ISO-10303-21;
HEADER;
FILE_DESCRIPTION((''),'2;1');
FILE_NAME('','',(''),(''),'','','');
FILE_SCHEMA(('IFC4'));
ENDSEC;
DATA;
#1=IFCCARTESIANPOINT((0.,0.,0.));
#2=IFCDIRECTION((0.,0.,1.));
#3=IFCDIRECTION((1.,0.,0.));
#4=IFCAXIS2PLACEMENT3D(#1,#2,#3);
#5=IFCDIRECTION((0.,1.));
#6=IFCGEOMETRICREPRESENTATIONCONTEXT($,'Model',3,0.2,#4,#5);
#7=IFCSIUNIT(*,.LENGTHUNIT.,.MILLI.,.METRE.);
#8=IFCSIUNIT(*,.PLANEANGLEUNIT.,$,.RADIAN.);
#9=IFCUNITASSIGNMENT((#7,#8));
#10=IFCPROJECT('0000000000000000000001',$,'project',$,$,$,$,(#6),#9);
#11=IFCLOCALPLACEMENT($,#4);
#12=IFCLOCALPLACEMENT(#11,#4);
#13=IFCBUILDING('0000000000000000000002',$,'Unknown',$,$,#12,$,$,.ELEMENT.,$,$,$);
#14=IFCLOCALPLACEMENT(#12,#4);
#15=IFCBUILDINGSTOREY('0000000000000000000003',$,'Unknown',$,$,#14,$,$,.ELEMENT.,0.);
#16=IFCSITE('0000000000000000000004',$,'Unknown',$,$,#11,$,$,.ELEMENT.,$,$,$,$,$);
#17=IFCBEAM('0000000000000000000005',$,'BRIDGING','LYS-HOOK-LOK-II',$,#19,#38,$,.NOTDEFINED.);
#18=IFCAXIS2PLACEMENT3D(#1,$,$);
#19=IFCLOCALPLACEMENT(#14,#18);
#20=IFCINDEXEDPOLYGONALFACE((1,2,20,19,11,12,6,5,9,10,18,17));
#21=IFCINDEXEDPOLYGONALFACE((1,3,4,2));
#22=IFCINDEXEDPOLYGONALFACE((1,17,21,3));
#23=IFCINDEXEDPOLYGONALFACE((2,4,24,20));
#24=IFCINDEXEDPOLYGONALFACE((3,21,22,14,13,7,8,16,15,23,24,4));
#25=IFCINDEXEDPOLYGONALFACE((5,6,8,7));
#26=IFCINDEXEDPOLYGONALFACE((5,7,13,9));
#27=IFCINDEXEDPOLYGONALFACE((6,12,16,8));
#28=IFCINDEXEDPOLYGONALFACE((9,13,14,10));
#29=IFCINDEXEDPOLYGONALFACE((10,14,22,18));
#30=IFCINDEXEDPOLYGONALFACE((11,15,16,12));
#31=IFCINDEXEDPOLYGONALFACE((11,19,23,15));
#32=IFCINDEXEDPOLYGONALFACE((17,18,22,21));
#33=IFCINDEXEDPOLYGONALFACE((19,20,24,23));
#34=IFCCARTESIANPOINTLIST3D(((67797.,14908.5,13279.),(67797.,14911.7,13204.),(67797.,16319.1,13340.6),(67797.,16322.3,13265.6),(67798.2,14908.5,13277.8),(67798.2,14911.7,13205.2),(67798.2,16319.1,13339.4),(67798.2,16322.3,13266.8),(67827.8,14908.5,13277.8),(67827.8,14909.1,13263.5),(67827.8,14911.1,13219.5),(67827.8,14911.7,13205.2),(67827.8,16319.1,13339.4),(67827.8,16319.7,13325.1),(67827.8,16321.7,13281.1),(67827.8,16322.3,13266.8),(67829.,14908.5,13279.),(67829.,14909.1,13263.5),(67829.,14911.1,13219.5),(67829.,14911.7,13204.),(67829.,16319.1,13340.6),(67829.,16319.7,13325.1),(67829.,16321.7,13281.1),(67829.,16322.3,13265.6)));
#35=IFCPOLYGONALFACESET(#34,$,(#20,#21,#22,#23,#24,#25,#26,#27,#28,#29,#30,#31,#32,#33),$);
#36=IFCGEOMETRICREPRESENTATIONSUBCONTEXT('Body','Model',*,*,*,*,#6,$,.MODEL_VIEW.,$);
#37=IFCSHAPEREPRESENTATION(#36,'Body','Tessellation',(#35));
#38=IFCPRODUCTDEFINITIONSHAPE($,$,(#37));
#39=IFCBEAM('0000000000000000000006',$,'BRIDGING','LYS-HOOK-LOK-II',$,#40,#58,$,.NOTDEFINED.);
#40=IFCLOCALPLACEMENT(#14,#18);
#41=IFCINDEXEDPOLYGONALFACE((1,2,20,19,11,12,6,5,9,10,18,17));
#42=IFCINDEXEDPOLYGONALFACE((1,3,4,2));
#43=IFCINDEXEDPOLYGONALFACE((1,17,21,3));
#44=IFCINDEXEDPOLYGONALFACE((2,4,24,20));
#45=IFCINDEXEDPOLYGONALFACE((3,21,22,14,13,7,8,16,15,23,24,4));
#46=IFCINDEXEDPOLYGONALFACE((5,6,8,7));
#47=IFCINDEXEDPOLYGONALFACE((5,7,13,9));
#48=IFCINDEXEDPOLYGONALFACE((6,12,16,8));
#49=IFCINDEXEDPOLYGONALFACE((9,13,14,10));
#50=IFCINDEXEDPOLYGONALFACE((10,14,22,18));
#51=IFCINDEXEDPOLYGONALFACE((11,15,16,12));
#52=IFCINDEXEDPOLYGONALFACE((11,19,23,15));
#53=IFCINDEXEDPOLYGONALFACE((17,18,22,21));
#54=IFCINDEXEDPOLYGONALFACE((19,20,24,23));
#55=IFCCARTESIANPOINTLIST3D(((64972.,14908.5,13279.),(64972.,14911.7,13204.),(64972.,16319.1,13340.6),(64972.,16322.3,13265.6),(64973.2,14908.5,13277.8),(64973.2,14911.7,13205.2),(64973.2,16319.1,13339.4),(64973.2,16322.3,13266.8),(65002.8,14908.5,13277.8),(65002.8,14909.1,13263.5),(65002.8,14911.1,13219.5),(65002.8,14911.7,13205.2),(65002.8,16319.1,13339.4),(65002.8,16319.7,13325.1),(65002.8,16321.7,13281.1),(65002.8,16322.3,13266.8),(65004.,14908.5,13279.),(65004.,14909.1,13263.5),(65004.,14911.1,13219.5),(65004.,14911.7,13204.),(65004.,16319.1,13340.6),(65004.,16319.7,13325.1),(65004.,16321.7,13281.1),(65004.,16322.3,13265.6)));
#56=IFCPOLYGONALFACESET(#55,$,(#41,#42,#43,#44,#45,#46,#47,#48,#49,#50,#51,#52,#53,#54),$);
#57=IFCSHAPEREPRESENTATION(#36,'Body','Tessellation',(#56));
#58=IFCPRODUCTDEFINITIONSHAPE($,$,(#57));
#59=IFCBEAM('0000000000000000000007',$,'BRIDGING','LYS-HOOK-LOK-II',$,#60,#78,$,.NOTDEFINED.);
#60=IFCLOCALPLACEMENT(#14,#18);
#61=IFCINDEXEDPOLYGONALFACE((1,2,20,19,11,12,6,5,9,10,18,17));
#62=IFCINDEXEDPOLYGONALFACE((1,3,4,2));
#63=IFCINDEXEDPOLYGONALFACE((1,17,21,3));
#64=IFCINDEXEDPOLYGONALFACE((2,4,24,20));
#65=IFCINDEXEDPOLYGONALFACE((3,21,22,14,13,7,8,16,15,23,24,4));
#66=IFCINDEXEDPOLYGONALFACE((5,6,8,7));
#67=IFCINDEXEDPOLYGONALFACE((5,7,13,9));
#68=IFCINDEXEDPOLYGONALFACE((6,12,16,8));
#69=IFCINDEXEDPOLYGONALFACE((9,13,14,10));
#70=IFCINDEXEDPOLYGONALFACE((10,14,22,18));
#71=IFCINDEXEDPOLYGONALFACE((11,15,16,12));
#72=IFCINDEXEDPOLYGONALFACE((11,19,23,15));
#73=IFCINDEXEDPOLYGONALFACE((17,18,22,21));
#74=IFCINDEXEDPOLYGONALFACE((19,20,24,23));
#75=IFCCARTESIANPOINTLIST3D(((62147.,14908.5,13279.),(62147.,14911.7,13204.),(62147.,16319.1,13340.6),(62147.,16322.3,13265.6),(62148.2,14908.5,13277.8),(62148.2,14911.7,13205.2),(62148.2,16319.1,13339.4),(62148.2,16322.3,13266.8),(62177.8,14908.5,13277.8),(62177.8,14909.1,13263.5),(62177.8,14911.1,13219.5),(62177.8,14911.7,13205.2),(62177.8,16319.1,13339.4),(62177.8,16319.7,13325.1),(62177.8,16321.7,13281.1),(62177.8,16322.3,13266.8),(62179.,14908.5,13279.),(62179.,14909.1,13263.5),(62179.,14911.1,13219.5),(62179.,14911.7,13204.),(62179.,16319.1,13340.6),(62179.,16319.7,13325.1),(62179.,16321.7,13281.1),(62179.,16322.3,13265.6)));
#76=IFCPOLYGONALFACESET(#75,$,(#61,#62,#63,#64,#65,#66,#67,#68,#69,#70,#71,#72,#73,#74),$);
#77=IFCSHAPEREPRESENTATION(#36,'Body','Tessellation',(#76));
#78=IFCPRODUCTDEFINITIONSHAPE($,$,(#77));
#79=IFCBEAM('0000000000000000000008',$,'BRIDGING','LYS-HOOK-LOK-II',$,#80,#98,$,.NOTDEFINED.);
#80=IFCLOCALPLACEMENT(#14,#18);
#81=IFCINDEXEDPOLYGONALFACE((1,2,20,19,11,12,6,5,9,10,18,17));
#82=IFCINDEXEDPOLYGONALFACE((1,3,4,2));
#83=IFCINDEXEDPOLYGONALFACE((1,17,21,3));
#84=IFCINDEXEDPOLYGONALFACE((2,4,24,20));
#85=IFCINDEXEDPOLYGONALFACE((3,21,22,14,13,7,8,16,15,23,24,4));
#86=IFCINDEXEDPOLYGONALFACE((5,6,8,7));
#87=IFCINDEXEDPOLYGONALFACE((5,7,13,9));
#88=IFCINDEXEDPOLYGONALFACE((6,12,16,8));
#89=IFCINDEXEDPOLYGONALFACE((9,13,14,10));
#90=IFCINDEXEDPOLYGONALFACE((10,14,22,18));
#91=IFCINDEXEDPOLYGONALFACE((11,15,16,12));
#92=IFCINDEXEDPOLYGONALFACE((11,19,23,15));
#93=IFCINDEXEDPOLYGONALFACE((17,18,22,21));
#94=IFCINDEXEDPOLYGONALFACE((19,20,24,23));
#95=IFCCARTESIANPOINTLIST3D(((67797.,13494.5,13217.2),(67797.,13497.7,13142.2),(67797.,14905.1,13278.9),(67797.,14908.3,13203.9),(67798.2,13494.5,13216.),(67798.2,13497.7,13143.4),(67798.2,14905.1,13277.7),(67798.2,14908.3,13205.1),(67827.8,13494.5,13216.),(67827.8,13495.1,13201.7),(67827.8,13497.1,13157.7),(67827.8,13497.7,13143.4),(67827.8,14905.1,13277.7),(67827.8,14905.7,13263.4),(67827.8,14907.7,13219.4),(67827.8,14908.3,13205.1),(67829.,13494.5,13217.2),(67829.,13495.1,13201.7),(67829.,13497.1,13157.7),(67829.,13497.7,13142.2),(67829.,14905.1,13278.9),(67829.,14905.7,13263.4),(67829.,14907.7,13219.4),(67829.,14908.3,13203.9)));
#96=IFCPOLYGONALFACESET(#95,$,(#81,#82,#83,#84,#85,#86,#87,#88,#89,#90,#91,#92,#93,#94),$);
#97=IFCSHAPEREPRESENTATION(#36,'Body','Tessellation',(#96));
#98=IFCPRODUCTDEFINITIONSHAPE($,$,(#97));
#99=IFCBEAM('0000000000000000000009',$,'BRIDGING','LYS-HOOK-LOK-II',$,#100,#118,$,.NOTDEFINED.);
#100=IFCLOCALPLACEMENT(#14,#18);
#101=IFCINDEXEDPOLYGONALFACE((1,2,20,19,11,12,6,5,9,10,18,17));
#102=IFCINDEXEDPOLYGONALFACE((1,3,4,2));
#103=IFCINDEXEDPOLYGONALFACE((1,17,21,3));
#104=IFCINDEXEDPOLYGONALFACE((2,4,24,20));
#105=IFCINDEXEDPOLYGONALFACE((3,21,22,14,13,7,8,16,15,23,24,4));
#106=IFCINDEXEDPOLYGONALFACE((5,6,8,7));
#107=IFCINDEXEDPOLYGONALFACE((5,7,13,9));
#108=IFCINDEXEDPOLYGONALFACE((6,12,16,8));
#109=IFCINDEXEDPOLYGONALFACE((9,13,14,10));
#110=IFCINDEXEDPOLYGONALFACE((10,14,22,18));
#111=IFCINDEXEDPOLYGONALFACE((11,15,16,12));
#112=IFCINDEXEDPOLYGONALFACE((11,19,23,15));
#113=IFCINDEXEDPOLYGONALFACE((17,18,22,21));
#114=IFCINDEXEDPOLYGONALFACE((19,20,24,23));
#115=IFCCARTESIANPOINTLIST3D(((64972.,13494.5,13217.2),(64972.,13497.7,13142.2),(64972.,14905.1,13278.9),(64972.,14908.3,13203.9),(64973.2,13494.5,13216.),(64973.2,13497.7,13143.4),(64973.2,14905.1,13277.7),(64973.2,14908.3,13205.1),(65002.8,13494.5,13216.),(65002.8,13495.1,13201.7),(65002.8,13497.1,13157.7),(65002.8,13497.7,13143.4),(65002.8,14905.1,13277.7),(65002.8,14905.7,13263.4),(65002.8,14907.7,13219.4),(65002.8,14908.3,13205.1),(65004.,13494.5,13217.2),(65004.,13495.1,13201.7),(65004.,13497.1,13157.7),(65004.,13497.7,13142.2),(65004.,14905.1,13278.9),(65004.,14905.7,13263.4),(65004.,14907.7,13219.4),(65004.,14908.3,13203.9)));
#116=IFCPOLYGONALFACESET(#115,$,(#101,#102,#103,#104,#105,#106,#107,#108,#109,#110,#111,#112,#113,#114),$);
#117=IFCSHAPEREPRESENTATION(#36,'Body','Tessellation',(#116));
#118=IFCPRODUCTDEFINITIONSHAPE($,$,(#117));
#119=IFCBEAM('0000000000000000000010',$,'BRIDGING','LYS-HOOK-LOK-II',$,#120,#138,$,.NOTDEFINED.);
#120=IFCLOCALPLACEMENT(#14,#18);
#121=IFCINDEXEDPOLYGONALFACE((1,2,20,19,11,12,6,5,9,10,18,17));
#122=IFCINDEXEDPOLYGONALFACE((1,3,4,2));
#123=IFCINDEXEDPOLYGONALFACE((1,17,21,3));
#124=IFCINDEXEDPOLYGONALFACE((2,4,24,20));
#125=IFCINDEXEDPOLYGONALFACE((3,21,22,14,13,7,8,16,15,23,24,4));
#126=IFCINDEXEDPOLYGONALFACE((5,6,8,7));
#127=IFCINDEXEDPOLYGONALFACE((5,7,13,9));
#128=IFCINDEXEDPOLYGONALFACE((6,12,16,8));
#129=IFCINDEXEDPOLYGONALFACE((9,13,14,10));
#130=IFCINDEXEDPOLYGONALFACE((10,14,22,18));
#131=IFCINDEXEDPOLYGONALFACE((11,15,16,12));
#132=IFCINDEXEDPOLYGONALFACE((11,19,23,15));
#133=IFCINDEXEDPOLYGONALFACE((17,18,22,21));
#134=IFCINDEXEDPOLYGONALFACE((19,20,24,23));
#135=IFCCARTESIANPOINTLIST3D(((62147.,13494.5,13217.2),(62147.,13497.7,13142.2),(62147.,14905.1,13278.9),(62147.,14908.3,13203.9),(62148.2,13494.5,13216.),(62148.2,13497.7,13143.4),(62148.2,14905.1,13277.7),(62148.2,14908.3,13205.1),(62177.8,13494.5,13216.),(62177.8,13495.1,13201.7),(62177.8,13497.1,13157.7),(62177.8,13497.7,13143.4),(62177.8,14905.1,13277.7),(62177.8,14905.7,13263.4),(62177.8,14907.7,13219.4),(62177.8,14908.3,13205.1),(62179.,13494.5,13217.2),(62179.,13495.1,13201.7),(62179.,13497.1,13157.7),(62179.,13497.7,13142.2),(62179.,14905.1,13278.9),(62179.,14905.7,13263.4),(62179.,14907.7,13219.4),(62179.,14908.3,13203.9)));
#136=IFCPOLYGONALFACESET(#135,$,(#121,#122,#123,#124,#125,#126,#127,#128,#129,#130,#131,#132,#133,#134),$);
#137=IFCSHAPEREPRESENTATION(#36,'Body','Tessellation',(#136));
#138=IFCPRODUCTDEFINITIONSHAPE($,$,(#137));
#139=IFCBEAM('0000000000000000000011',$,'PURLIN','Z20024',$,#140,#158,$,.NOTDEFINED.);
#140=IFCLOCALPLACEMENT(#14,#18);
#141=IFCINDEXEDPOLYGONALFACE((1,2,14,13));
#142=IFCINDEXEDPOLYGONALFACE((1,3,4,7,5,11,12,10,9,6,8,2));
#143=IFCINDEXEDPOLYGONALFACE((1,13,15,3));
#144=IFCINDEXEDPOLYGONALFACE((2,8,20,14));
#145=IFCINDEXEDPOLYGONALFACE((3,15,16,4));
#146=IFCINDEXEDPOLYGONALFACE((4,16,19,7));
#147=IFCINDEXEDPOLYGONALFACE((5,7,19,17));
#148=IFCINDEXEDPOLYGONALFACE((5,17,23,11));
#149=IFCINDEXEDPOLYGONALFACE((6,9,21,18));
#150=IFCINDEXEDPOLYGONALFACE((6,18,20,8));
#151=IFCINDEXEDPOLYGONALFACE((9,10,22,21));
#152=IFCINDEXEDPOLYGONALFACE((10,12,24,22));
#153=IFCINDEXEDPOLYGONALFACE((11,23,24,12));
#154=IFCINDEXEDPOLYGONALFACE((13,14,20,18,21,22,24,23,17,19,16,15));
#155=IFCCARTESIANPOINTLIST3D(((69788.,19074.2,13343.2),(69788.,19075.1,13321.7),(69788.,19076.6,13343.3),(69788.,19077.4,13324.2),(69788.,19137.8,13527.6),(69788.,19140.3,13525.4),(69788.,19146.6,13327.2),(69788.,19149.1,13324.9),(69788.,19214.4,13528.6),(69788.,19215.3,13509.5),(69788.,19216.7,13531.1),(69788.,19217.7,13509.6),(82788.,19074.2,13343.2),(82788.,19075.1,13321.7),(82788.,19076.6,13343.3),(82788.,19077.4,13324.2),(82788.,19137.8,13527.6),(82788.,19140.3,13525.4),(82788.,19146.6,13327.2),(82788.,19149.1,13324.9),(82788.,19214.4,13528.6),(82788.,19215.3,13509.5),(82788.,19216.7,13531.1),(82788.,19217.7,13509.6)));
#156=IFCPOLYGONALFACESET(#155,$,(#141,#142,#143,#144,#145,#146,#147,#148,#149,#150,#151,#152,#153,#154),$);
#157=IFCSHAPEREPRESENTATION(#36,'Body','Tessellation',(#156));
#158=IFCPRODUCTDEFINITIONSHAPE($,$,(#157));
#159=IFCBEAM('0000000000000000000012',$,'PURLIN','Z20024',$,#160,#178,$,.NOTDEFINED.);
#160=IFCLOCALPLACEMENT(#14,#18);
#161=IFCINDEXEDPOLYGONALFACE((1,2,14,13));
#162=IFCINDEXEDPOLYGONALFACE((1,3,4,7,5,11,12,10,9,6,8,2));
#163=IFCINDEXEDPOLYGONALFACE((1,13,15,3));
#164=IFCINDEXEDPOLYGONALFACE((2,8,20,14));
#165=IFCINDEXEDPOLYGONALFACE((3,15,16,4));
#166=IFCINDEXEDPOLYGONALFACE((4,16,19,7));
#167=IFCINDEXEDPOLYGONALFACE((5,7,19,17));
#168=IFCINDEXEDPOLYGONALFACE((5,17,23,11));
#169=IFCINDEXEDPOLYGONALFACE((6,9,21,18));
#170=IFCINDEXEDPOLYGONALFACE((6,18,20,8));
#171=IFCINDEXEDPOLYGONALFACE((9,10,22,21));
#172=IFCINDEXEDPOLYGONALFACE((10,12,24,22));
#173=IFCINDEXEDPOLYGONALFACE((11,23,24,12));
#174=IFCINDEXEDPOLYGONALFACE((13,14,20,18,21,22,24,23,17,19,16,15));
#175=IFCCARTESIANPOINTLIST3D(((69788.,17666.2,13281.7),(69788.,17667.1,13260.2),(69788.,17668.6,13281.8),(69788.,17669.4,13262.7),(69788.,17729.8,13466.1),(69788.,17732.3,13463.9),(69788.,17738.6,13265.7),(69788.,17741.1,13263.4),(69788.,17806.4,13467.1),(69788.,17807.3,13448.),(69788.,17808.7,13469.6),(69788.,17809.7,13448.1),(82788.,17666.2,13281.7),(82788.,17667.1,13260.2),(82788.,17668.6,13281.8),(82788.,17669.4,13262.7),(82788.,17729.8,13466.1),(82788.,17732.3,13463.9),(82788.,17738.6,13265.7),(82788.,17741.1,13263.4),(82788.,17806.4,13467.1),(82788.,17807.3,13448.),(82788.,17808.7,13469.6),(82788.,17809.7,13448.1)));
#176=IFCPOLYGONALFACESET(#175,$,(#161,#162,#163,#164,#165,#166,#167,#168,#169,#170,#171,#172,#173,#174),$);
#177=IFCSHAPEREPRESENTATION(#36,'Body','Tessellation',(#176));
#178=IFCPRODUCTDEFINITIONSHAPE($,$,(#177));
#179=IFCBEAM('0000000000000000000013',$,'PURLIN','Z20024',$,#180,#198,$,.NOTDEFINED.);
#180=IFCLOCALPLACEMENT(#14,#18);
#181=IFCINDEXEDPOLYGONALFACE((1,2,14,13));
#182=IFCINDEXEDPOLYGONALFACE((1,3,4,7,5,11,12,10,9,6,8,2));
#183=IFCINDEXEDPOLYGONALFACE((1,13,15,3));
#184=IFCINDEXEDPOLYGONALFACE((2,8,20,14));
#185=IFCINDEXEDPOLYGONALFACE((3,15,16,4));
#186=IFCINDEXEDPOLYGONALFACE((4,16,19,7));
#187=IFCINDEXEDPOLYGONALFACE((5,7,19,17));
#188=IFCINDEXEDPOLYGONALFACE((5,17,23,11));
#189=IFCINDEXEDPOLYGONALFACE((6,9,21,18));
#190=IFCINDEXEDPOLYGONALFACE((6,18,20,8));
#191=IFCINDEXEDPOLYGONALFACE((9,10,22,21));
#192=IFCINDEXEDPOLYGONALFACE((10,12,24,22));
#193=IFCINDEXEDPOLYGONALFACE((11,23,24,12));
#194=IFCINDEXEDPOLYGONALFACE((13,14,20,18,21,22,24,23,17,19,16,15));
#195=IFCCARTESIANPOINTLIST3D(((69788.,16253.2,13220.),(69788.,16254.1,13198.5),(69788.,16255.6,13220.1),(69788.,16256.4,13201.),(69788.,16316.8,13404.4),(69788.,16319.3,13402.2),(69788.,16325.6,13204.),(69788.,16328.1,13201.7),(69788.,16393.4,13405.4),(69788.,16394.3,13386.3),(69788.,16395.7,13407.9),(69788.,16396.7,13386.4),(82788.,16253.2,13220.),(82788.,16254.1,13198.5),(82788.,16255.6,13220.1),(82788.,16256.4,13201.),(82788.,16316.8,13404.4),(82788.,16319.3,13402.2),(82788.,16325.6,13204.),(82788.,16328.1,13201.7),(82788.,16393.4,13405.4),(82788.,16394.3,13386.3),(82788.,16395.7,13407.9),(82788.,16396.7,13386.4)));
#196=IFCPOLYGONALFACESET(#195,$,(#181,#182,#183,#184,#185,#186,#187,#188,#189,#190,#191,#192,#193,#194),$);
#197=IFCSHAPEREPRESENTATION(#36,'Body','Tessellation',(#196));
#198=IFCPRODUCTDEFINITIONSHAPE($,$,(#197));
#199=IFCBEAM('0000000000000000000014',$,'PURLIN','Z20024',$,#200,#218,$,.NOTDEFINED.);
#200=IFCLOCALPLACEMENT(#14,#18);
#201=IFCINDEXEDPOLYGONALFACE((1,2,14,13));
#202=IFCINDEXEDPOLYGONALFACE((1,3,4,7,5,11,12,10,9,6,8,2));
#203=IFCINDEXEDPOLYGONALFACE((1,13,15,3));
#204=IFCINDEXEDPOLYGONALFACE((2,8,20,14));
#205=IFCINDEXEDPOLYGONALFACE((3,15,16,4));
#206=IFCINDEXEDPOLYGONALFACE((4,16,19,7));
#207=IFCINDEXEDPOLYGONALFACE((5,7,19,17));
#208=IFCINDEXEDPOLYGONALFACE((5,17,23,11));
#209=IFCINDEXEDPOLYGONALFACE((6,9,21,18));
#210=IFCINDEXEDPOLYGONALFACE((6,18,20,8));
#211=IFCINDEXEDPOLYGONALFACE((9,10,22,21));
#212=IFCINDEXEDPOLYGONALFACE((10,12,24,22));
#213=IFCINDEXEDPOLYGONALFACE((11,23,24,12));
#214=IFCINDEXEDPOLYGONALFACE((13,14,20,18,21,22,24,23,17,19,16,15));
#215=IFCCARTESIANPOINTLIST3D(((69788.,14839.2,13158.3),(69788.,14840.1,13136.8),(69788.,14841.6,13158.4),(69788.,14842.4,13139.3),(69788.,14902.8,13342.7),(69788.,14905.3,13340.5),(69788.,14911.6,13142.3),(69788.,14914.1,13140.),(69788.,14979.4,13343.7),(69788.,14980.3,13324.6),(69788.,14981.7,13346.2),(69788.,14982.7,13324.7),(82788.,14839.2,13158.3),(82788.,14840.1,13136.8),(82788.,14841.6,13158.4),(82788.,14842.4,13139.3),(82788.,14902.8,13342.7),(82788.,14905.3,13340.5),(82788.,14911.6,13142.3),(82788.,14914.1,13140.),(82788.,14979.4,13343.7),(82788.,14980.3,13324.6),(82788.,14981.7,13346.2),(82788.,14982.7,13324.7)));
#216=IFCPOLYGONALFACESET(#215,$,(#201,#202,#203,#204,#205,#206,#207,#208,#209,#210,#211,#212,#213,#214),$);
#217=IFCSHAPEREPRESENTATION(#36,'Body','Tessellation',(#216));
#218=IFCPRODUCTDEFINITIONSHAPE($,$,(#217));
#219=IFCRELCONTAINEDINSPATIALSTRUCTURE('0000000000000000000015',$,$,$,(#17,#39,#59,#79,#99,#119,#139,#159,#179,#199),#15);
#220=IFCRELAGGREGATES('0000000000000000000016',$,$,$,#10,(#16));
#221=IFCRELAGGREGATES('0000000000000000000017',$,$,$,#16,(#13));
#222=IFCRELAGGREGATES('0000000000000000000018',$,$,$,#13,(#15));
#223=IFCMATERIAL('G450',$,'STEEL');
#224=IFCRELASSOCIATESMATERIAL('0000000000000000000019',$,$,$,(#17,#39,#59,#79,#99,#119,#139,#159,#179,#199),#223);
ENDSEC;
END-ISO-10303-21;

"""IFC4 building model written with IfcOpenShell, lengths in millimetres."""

from ifc_helpers import new_model, si_unit, direction, frame, origin_with_axes, place, context, subcontext, project, spatial, line, indexed_curve, outline, extrude, material, element, save


model = new_model("IFC4")

# Units and contexts
model_context = context("Model", 3, precision=0.2, world=origin_with_axes(), true_north=direction((0.0, 1.0)))
body_context = subcontext(model_context, "Body", "Model", "MODEL_VIEW")
ifc_project = project(units=[si_unit("LENGTHUNIT", "METRE", prefix="MILLI"), si_unit("PLANEANGLEUNIT", "RADIAN")], contexts=[model_context])

# Site, building, storey
site_placement = place(None, origin_with_axes())
site = spatial("IfcSite", under=ifc_project, at=site_placement, Name="Unknown", CompositionType="ELEMENT")
building_placement = place(site_placement, origin_with_axes())
building = spatial("IfcBuilding", under=site, at=building_placement, Name="Unknown", CompositionType="ELEMENT")
storey_placement = place(building_placement, origin_with_axes())
storey = spatial("IfcBuildingStorey", under=building, at=storey_placement, Name="Unknown", CompositionType="ELEMENT", Elevation=0.0)

# Beams
ifc_material_1 = material(Name="G450", Category="STEEL")
for number, where, z_axis, x_axis, name in (
    (1, (67813.0, 14910.1, 13241.5), (1.0, 0.0, 0.0), (0.0, 0.999048, 0.043628), "BRIDGING"),
    (2, (64988.0, 14910.1, 13241.5), (1.0, 0.0, 0.0), (0.0, 0.999048, 0.043628), "BRIDGING"),
    (3, (62163.0, 14910.1, 13241.5), (1.0, 0.0, 0.0), (0.0, 0.999048, 0.043628), "BRIDGING"),
):
    element("IfcBeam", number, at=place(storey_placement, frame(where, z_axis=z_axis, x_axis=x_axis)), inside=storey, material=ifc_material_1, Name=name, Description="LYS-HOOK-LOK-II", PredefinedType="NOTDEFINED", context=body_context, shape_type="SolidModel", body=[
        extrude(outline(indexed_curve([(16.0, -37.5), (16.0, -22.0), (14.8, -22.0), (14.8, -36.3), (-14.8, -36.3), (-14.8, 36.3), (14.8, 36.3), (14.8, 22.0), (16.0, 22.0), (16.0, 37.5), (-16.0, 37.5), (-16.0, -37.5)], segments=[line(1, 2, 3, 4, 5, 6, 7, 8, 9, 10, 11, 12, 1)])), frame((0.0, 0.0, 0.0), z_axis=(-1.0, 0.0, 0.0), x_axis=(0.0, 0.0, 1.0)), (0.0, 0.0, -1.0), 1411.9),
    ])
for number, where, z_axis, x_axis, name in (
    (4, (67813.0, 13496.1, 13179.7), (1.0, 0.0, 0.0), (0.0, 0.999045, 0.043698), "BRIDGING"),
    (5, (64988.0, 13496.1, 13179.7), (1.0, 0.0, 0.0), (0.0, 0.999045, 0.043698), "BRIDGING"),
    (6, (62163.0, 13496.1, 13179.7), (1.0, 0.0, 0.0), (0.0, 0.999045, 0.043698), "BRIDGING"),
):
    element("IfcBeam", number, at=place(storey_placement, frame(where, z_axis=z_axis, x_axis=x_axis)), inside=storey, material=ifc_material_1, Name=name, Description="LYS-HOOK-LOK-II", PredefinedType="NOTDEFINED", context=body_context, shape_type="SolidModel", body=[
        extrude(outline(indexed_curve([(16.0, -37.5), (16.0, -22.0), (14.8, -22.0), (14.8, -36.3), (-14.8, -36.3), (-14.8, 36.3), (14.8, 36.3), (14.8, 22.0), (16.0, 22.0), (16.0, 37.5), (-16.0, 37.5), (-16.0, -37.5)], segments=[line(1, 2, 3, 4, 5, 6, 7, 8, 9, 10, 11, 12, 1)])), frame((0.0, 0.0, 0.0), z_axis=(-1.0, 0.0, 0.0), x_axis=(0.0, 0.0, 1.0)), (0.0, 0.0, -1.0), 1411.9),
    ])
for number, where, z_axis, x_axis, name in (
    (7, (69788.0, 19143.4, 13426.3), (0.0, -0.999048, -0.043619), (1.0, 0.0, 0.0), "PURLIN"),
    (8, (69788.0, 17735.4, 13364.8), (0.0, -0.999048, -0.043619), (1.0, 0.0, 0.0), "PURLIN"),
    (9, (69788.0, 16322.4, 13303.1), (0.0, -0.999048, -0.043619), (1.0, 0.0, 0.0), "PURLIN"),
    (10, (69788.0, 14908.4, 13241.4), (0.0, -0.999048, -0.043619), (1.0, 0.0, 0.0), "PURLIN"),
):
    element("IfcBeam", number, at=place(storey_placement, frame(where, z_axis=z_axis, x_axis=x_axis)), inside=storey, material=ifc_material_1, Name=name, Description="Z20024", PredefinedType="NOTDEFINED", context=body_context, shape_type="SolidModel", body=[
        extrude(outline(indexed_curve([(72.8, -101.5), (72.8, -80.0), (70.4, -80.0), (70.4, -99.1), (1.2, -99.1), (1.2, 101.5), (-77.8, 101.5), (-77.8, 80.0), (-75.4, 80.0), (-75.4, 99.1), (-1.2, 99.1), (-1.2, -101.5)], segments=[line(1, 2, 3, 4, 5, 6, 7, 8, 9, 10, 11, 12, 1)])), frame((0.0, 0.0, 0.0), z_axis=(-1.0, 0.0, 0.0), x_axis=(0.0, 0.0, 1.0)), (0.0, 0.0, -1.0), 13000.0),
    ])

save(model, "model.ifc")
